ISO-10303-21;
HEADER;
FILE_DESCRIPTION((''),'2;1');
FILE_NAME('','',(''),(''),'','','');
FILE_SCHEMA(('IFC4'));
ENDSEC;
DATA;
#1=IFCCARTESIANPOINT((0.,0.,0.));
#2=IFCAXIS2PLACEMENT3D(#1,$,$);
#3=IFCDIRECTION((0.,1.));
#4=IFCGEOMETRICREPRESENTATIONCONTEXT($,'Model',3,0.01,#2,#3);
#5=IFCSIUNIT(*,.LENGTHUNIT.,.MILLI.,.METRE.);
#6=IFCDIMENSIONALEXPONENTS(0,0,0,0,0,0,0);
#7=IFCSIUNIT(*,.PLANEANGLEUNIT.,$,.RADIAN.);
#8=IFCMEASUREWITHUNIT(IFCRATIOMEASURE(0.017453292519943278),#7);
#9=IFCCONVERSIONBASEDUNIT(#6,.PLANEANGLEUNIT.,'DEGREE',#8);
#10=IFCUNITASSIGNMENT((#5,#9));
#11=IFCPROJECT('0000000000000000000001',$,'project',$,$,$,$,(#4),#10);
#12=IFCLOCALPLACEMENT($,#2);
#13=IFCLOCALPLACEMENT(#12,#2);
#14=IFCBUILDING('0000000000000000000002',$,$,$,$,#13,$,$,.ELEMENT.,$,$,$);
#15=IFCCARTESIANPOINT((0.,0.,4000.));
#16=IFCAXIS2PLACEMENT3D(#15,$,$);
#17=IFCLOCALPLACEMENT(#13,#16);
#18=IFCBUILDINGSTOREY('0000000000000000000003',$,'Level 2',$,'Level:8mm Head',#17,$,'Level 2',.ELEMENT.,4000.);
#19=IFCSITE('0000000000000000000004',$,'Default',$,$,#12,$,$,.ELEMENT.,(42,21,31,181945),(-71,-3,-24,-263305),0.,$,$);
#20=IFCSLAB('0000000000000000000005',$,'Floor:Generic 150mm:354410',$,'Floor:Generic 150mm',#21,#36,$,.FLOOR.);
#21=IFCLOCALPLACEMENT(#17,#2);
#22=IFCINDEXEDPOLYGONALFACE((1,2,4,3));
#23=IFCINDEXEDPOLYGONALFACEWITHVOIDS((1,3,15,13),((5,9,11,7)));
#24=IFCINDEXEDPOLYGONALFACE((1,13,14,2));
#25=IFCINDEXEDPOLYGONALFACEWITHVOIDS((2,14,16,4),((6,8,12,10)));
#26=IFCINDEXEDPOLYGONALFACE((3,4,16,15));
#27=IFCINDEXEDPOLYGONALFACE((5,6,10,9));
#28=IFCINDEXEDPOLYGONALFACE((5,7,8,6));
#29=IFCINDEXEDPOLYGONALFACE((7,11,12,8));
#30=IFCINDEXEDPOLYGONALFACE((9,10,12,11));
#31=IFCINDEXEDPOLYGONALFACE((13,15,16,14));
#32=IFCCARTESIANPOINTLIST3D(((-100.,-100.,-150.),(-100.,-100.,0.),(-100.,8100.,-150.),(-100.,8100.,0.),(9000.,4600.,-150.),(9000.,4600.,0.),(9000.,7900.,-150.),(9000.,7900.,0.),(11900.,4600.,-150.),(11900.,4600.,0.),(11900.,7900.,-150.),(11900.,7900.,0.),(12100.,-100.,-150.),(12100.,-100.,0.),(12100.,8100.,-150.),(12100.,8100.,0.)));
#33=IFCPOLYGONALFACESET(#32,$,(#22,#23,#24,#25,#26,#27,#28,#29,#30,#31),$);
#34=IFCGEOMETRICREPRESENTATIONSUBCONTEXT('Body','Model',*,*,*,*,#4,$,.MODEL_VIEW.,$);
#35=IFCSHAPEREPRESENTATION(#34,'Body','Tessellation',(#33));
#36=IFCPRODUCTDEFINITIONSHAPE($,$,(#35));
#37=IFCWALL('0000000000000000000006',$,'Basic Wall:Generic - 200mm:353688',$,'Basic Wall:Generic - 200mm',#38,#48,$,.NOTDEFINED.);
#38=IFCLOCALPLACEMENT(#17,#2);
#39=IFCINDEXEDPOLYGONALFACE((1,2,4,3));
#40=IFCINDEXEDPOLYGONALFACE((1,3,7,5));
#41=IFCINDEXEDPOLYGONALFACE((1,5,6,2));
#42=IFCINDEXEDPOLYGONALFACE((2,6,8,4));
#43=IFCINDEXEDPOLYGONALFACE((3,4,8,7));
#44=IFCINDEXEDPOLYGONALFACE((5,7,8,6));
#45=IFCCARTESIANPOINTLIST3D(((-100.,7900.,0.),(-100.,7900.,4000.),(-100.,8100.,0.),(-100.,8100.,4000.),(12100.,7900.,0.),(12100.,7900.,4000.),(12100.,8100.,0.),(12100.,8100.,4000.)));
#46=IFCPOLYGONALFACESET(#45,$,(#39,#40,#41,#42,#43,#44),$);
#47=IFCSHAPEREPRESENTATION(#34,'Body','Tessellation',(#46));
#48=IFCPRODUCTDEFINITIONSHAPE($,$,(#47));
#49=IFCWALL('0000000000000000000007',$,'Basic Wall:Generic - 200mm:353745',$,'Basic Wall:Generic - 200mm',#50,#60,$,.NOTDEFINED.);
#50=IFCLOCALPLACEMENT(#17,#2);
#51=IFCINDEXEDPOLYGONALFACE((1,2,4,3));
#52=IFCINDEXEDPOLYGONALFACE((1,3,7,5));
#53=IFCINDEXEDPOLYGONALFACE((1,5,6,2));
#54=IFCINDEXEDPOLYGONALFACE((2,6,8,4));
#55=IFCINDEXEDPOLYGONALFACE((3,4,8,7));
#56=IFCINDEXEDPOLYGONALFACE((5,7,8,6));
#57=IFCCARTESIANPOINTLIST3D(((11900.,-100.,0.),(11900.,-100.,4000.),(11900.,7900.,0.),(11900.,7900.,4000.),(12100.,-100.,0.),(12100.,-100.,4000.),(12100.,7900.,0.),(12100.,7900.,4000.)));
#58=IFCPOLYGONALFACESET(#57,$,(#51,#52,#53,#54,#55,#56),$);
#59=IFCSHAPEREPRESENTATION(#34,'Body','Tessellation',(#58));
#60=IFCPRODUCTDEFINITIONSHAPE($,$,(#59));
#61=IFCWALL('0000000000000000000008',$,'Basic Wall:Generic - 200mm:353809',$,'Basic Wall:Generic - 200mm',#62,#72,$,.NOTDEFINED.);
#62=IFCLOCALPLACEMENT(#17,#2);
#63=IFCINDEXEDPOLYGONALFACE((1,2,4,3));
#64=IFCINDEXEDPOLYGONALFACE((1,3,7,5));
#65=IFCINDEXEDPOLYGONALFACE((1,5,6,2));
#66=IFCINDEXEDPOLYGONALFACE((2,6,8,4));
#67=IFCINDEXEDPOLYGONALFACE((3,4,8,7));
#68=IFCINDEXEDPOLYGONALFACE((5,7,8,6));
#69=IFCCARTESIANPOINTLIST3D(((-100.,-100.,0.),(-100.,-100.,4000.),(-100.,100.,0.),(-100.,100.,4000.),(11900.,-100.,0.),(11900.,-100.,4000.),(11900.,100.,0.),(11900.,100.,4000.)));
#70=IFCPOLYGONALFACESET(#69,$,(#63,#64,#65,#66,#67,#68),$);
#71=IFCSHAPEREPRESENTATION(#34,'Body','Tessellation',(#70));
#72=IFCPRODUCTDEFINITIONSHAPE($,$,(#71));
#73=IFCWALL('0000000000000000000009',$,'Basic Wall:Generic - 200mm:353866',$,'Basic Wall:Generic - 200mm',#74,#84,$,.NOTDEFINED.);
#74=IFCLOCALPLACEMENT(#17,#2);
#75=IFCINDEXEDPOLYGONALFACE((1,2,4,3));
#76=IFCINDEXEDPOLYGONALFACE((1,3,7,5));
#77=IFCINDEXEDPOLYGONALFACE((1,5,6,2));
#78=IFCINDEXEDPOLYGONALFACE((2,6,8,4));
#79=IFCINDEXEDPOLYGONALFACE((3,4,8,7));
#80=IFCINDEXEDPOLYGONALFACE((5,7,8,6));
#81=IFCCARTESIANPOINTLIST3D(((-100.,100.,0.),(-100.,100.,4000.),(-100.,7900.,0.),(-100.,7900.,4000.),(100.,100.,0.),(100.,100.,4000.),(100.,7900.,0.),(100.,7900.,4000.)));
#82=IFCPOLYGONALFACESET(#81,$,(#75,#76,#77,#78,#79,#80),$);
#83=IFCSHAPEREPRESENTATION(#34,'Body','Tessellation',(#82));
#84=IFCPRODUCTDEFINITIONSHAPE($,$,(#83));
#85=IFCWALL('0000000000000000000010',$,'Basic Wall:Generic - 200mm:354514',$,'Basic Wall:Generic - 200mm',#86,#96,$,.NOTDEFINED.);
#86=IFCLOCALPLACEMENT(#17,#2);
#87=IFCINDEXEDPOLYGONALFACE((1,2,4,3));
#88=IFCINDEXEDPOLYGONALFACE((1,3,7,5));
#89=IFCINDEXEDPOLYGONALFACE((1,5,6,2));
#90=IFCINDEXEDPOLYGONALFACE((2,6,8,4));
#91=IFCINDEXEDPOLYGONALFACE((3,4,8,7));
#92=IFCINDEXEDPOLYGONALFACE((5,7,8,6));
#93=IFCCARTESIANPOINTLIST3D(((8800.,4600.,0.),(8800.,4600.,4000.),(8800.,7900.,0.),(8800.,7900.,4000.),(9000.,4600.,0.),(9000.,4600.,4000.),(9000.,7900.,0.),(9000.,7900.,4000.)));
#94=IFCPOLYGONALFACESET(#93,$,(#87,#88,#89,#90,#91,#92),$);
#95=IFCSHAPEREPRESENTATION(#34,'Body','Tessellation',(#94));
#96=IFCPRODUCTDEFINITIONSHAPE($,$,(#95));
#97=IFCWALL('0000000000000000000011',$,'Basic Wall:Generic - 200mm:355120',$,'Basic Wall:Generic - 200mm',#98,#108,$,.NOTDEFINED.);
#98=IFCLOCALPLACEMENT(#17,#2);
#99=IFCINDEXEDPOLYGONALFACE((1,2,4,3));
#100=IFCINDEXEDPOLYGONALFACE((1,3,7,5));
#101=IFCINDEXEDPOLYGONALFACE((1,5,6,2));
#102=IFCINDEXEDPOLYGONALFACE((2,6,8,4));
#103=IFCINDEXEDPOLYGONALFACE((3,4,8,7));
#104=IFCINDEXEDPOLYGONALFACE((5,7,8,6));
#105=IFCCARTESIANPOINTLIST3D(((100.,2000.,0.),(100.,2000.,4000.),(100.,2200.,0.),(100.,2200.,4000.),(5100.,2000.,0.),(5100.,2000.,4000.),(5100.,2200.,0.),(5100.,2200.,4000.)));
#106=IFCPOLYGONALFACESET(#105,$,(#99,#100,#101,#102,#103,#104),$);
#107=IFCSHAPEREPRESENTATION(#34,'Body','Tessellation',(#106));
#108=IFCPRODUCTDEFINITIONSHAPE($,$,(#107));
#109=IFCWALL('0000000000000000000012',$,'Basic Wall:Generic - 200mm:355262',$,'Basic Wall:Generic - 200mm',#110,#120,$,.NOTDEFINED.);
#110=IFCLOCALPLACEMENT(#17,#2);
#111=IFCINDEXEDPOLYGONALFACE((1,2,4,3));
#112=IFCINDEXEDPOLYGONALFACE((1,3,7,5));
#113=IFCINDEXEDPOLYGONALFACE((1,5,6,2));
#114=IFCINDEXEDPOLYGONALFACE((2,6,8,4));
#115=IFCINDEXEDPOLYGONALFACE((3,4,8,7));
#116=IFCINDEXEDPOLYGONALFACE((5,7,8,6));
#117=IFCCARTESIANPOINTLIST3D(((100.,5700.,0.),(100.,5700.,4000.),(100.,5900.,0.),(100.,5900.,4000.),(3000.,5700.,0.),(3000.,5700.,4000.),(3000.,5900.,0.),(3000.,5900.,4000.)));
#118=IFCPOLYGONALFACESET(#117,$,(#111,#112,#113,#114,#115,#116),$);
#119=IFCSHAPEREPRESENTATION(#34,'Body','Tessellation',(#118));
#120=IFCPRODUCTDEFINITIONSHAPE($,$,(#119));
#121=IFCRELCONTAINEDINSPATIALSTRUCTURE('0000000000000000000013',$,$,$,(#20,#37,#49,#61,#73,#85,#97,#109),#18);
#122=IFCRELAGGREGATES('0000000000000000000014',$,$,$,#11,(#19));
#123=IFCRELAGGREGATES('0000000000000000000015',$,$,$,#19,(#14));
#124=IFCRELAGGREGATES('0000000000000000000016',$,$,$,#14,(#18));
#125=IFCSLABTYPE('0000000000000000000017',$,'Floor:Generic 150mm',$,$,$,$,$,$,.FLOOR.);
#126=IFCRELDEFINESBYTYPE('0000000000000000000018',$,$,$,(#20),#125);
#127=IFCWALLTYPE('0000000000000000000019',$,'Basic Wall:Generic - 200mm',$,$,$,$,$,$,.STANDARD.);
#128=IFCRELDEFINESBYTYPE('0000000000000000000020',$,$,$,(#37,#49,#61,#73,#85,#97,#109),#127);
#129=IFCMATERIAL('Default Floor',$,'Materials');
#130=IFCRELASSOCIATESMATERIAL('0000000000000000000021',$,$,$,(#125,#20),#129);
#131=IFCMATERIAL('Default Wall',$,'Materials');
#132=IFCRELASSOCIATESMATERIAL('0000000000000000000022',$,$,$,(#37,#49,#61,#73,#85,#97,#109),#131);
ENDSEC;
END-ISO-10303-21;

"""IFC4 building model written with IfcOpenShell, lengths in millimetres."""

from ifc_helpers import new_model, entity, si_unit, converted_unit, direction, frame, origin, place, context, subcontext, project, spatial, indexed_curve, outline, extrude, material, type_object, element, save


model = new_model("IFC4")

# Units and contexts
model_context = context("Model", 3, precision=0.01, world=origin(), true_north=direction((0.0, 1.0)))
body_context = subcontext(model_context, "Body", "Model", "MODEL_VIEW")
ifc_project = project(units=[si_unit("LENGTHUNIT", "METRE", prefix="MILLI"), converted_unit("PLANEANGLEUNIT", "DEGREE", entity("IfcRatioMeasure", 0.017453292519943278), si_unit("PLANEANGLEUNIT", "RADIAN"), dimensions=[0, 0, 0, 0, 0, 0, 0])], contexts=[model_context])

# Site, building, storey
site_placement = place(None, origin())
site = spatial("IfcSite", under=ifc_project, at=site_placement, Name="Default", CompositionType="ELEMENT", RefLatitude=(42, 21, 31, 181945), RefLongitude=(-71, -3, -24, -263305), RefElevation=0.0)
building_placement = place(site_placement, origin())
building = spatial("IfcBuilding", under=site, at=building_placement, CompositionType="ELEMENT")
storey_placement = place(building_placement, frame((0.0, 0.0, 4000.0)))
storey = spatial("IfcBuildingStorey", under=building, at=storey_placement, Name="Level 2", ObjectType="Level:8mm Head", LongName="Level 2", CompositionType="ELEMENT", Elevation=4000.0)

# Slab, opening
ifc_material_1 = material(Name="Default Floor", Category="Materials")
slab_type = type_object("IfcSlabType", Name="Floor:Generic 150mm", PredefinedType="FLOOR", material=ifc_material_1)
slab_placement = place(storey_placement, origin())
slab = element("IfcSlab", 1, at=slab_placement, inside=storey, type_object=slab_type, material=ifc_material_1, Name="Floor:Generic 150mm:354410", ObjectType="Floor:Generic 150mm", PredefinedType="FLOOR", context=body_context, shape_type="SweptSolid", body=[
    extrude(outline(indexed_curve([(-6100.0, -4100.0), (6100.0, -4100.0), (6100.0, 4100.0), (-6100.0, 4100.0), (-6100.0, -4100.0)], self_intersect=False), holes=[indexed_curve([(-5900.0, -3900.0), (-5900.0, -600.0), (-3000.0, -600.0), (-3000.0, -3900.0), (-5900.0, -3900.0)], self_intersect=False)]), frame((6000.0, 4000.0, -150.0), z_axis=(0.0, 0.0, 1.0), x_axis=(-1.0, 0.0, 0.0)), (0.0, 0.0, 1.0), 150.0),
])
opening_placement = place(slab_placement, origin())
element("IfcOpeningElement", 2, at=opening_placement, cuts=slab, PredefinedType="OPENING", context=body_context, shape_type="SweptSolid", body=[
    extrude(outline(indexed_curve([(-1650.0, -1450.0), (1650.0, -1450.0), (1650.0, 1450.0), (-1650.0, 1450.0), (-1650.0, -1450.0)], self_intersect=False)), frame((10450.0, 6250.0, 0.0), z_axis=(0.0, 0.0, -1.0), x_axis=(0.0, -1.0, 0.0)), (0.0, 0.0, 1.0), 8200.0),
])

# Walls
ifc_material_2 = material(Name="Default Wall", Category="Materials")
wall_type = type_object("IfcWallType", Name="Basic Wall:Generic - 200mm", PredefinedType="STANDARD")
wall_1_placement = place(storey_placement, frame((-100.0, 8000.0, 0.0)))
element("IfcWall", 3, at=wall_1_placement, inside=storey, type_object=wall_type, material=ifc_material_2, Name="Basic Wall:Generic - 200mm:353688", ObjectType="Basic Wall:Generic - 200mm", PredefinedType="NOTDEFINED", context=body_context, shape_type="SweptSolid", body=[
    extrude(outline(indexed_curve([(12200.0, 100.0), (0.0, 100.0), (0.0, -100.0), (12200.0, -100.0), (12200.0, 100.0)], self_intersect=False)), origin(), (0.0, 0.0, 1.0), 4000.0),
])
wall_2_placement = place(storey_placement, frame((12000.0, 7900.0, 0.0), z_axis=(0.0, 0.0, 1.0), x_axis=(0.0, -1.0, 0.0)))
element("IfcWall", 4, at=wall_2_placement, inside=storey, type_object=wall_type, material=ifc_material_2, Name="Basic Wall:Generic - 200mm:353745", ObjectType="Basic Wall:Generic - 200mm", PredefinedType="NOTDEFINED", context=body_context, shape_type="SweptSolid", body=[
    extrude(outline(indexed_curve([(8000.0, 100.0), (0.0, 100.0), (0.0, -100.0), (8000.0, -100.0), (8000.0, 100.0)], self_intersect=False)), origin(), (0.0, 0.0, 1.0), 4000.0),
])
wall_3_placement = place(storey_placement, frame((11900.0, 0.0, 0.0), z_axis=(0.0, 0.0, 1.0), x_axis=(-1.0, 0.0, 0.0)))
element("IfcWall", 5, at=wall_3_placement, inside=storey, type_object=wall_type, material=ifc_material_2, Name="Basic Wall:Generic - 200mm:353809", ObjectType="Basic Wall:Generic - 200mm", PredefinedType="NOTDEFINED", context=body_context, shape_type="SweptSolid", body=[
    extrude(outline(indexed_curve([(12000.0, 100.0), (0.0, 100.0), (0.0, -100.0), (12000.0, -100.0), (12000.0, 100.0)], self_intersect=False)), origin(), (0.0, 0.0, 1.0), 4000.0),
])
wall_4_placement = place(storey_placement, frame((0.0, 100.0, 0.0), z_axis=(0.0, 0.0, 1.0), x_axis=(0.0, 1.0, 0.0)))
element("IfcWall", 6, at=wall_4_placement, inside=storey, type_object=wall_type, material=ifc_material_2, Name="Basic Wall:Generic - 200mm:353866", ObjectType="Basic Wall:Generic - 200mm", PredefinedType="NOTDEFINED", context=body_context, shape_type="SweptSolid", body=[
    extrude(outline(indexed_curve([(7800.0, 100.0), (0.0, 100.0), (0.0, -100.0), (7800.0, -100.0), (7800.0, 100.0)], self_intersect=False)), origin(), (0.0, 0.0, 1.0), 4000.0),
])
wall_5_placement = place(storey_placement, frame((8900.0, 7900.0, 0.0), z_axis=(0.0, 0.0, 1.0), x_axis=(0.0, -1.0, 0.0)))
element("IfcWall", 7, at=wall_5_placement, inside=storey, type_object=wall_type, material=ifc_material_2, Name="Basic Wall:Generic - 200mm:354514", ObjectType="Basic Wall:Generic - 200mm", PredefinedType="NOTDEFINED", context=body_context, shape_type="SweptSolid", body=[
    extrude(outline(indexed_curve([(3300.0, 100.0), (0.0, 100.0), (0.0, -100.0), (3300.0, -100.0), (3300.0, 100.0)], self_intersect=False)), origin(), (0.0, 0.0, 1.0), 4000.0),
])
wall_6_placement = place(storey_placement, frame((100.0, 2100.0, 0.0)))
element("IfcWall", 8, at=wall_6_placement, inside=storey, type_object=wall_type, material=ifc_material_2, Name="Basic Wall:Generic - 200mm:355120", ObjectType="Basic Wall:Generic - 200mm", PredefinedType="NOTDEFINED", context=body_context, shape_type="SweptSolid", body=[
    extrude(outline(indexed_curve([(5000.0, 100.0), (0.0, 100.0), (0.0, -100.0), (5000.0, -100.0), (5000.0, 100.0)], self_intersect=False)), origin(), (0.0, 0.0, 1.0), 4000.0),
])
wall_7_placement = place(storey_placement, frame((100.0, 5800.0, 0.0)))
element("IfcWall", 9, at=wall_7_placement, inside=storey, type_object=wall_type, material=ifc_material_2, Name="Basic Wall:Generic - 200mm:355262", ObjectType="Basic Wall:Generic - 200mm", PredefinedType="NOTDEFINED", context=body_context, shape_type="SweptSolid", body=[
    extrude(outline(indexed_curve([(2900.0, 100.0), (0.0, 100.0), (0.0, -100.0), (2900.0, -100.0), (2900.0, 100.0)], self_intersect=False)), origin(), (0.0, 0.0, 1.0), 4000.0),
])

save(model, "model.ifc")
